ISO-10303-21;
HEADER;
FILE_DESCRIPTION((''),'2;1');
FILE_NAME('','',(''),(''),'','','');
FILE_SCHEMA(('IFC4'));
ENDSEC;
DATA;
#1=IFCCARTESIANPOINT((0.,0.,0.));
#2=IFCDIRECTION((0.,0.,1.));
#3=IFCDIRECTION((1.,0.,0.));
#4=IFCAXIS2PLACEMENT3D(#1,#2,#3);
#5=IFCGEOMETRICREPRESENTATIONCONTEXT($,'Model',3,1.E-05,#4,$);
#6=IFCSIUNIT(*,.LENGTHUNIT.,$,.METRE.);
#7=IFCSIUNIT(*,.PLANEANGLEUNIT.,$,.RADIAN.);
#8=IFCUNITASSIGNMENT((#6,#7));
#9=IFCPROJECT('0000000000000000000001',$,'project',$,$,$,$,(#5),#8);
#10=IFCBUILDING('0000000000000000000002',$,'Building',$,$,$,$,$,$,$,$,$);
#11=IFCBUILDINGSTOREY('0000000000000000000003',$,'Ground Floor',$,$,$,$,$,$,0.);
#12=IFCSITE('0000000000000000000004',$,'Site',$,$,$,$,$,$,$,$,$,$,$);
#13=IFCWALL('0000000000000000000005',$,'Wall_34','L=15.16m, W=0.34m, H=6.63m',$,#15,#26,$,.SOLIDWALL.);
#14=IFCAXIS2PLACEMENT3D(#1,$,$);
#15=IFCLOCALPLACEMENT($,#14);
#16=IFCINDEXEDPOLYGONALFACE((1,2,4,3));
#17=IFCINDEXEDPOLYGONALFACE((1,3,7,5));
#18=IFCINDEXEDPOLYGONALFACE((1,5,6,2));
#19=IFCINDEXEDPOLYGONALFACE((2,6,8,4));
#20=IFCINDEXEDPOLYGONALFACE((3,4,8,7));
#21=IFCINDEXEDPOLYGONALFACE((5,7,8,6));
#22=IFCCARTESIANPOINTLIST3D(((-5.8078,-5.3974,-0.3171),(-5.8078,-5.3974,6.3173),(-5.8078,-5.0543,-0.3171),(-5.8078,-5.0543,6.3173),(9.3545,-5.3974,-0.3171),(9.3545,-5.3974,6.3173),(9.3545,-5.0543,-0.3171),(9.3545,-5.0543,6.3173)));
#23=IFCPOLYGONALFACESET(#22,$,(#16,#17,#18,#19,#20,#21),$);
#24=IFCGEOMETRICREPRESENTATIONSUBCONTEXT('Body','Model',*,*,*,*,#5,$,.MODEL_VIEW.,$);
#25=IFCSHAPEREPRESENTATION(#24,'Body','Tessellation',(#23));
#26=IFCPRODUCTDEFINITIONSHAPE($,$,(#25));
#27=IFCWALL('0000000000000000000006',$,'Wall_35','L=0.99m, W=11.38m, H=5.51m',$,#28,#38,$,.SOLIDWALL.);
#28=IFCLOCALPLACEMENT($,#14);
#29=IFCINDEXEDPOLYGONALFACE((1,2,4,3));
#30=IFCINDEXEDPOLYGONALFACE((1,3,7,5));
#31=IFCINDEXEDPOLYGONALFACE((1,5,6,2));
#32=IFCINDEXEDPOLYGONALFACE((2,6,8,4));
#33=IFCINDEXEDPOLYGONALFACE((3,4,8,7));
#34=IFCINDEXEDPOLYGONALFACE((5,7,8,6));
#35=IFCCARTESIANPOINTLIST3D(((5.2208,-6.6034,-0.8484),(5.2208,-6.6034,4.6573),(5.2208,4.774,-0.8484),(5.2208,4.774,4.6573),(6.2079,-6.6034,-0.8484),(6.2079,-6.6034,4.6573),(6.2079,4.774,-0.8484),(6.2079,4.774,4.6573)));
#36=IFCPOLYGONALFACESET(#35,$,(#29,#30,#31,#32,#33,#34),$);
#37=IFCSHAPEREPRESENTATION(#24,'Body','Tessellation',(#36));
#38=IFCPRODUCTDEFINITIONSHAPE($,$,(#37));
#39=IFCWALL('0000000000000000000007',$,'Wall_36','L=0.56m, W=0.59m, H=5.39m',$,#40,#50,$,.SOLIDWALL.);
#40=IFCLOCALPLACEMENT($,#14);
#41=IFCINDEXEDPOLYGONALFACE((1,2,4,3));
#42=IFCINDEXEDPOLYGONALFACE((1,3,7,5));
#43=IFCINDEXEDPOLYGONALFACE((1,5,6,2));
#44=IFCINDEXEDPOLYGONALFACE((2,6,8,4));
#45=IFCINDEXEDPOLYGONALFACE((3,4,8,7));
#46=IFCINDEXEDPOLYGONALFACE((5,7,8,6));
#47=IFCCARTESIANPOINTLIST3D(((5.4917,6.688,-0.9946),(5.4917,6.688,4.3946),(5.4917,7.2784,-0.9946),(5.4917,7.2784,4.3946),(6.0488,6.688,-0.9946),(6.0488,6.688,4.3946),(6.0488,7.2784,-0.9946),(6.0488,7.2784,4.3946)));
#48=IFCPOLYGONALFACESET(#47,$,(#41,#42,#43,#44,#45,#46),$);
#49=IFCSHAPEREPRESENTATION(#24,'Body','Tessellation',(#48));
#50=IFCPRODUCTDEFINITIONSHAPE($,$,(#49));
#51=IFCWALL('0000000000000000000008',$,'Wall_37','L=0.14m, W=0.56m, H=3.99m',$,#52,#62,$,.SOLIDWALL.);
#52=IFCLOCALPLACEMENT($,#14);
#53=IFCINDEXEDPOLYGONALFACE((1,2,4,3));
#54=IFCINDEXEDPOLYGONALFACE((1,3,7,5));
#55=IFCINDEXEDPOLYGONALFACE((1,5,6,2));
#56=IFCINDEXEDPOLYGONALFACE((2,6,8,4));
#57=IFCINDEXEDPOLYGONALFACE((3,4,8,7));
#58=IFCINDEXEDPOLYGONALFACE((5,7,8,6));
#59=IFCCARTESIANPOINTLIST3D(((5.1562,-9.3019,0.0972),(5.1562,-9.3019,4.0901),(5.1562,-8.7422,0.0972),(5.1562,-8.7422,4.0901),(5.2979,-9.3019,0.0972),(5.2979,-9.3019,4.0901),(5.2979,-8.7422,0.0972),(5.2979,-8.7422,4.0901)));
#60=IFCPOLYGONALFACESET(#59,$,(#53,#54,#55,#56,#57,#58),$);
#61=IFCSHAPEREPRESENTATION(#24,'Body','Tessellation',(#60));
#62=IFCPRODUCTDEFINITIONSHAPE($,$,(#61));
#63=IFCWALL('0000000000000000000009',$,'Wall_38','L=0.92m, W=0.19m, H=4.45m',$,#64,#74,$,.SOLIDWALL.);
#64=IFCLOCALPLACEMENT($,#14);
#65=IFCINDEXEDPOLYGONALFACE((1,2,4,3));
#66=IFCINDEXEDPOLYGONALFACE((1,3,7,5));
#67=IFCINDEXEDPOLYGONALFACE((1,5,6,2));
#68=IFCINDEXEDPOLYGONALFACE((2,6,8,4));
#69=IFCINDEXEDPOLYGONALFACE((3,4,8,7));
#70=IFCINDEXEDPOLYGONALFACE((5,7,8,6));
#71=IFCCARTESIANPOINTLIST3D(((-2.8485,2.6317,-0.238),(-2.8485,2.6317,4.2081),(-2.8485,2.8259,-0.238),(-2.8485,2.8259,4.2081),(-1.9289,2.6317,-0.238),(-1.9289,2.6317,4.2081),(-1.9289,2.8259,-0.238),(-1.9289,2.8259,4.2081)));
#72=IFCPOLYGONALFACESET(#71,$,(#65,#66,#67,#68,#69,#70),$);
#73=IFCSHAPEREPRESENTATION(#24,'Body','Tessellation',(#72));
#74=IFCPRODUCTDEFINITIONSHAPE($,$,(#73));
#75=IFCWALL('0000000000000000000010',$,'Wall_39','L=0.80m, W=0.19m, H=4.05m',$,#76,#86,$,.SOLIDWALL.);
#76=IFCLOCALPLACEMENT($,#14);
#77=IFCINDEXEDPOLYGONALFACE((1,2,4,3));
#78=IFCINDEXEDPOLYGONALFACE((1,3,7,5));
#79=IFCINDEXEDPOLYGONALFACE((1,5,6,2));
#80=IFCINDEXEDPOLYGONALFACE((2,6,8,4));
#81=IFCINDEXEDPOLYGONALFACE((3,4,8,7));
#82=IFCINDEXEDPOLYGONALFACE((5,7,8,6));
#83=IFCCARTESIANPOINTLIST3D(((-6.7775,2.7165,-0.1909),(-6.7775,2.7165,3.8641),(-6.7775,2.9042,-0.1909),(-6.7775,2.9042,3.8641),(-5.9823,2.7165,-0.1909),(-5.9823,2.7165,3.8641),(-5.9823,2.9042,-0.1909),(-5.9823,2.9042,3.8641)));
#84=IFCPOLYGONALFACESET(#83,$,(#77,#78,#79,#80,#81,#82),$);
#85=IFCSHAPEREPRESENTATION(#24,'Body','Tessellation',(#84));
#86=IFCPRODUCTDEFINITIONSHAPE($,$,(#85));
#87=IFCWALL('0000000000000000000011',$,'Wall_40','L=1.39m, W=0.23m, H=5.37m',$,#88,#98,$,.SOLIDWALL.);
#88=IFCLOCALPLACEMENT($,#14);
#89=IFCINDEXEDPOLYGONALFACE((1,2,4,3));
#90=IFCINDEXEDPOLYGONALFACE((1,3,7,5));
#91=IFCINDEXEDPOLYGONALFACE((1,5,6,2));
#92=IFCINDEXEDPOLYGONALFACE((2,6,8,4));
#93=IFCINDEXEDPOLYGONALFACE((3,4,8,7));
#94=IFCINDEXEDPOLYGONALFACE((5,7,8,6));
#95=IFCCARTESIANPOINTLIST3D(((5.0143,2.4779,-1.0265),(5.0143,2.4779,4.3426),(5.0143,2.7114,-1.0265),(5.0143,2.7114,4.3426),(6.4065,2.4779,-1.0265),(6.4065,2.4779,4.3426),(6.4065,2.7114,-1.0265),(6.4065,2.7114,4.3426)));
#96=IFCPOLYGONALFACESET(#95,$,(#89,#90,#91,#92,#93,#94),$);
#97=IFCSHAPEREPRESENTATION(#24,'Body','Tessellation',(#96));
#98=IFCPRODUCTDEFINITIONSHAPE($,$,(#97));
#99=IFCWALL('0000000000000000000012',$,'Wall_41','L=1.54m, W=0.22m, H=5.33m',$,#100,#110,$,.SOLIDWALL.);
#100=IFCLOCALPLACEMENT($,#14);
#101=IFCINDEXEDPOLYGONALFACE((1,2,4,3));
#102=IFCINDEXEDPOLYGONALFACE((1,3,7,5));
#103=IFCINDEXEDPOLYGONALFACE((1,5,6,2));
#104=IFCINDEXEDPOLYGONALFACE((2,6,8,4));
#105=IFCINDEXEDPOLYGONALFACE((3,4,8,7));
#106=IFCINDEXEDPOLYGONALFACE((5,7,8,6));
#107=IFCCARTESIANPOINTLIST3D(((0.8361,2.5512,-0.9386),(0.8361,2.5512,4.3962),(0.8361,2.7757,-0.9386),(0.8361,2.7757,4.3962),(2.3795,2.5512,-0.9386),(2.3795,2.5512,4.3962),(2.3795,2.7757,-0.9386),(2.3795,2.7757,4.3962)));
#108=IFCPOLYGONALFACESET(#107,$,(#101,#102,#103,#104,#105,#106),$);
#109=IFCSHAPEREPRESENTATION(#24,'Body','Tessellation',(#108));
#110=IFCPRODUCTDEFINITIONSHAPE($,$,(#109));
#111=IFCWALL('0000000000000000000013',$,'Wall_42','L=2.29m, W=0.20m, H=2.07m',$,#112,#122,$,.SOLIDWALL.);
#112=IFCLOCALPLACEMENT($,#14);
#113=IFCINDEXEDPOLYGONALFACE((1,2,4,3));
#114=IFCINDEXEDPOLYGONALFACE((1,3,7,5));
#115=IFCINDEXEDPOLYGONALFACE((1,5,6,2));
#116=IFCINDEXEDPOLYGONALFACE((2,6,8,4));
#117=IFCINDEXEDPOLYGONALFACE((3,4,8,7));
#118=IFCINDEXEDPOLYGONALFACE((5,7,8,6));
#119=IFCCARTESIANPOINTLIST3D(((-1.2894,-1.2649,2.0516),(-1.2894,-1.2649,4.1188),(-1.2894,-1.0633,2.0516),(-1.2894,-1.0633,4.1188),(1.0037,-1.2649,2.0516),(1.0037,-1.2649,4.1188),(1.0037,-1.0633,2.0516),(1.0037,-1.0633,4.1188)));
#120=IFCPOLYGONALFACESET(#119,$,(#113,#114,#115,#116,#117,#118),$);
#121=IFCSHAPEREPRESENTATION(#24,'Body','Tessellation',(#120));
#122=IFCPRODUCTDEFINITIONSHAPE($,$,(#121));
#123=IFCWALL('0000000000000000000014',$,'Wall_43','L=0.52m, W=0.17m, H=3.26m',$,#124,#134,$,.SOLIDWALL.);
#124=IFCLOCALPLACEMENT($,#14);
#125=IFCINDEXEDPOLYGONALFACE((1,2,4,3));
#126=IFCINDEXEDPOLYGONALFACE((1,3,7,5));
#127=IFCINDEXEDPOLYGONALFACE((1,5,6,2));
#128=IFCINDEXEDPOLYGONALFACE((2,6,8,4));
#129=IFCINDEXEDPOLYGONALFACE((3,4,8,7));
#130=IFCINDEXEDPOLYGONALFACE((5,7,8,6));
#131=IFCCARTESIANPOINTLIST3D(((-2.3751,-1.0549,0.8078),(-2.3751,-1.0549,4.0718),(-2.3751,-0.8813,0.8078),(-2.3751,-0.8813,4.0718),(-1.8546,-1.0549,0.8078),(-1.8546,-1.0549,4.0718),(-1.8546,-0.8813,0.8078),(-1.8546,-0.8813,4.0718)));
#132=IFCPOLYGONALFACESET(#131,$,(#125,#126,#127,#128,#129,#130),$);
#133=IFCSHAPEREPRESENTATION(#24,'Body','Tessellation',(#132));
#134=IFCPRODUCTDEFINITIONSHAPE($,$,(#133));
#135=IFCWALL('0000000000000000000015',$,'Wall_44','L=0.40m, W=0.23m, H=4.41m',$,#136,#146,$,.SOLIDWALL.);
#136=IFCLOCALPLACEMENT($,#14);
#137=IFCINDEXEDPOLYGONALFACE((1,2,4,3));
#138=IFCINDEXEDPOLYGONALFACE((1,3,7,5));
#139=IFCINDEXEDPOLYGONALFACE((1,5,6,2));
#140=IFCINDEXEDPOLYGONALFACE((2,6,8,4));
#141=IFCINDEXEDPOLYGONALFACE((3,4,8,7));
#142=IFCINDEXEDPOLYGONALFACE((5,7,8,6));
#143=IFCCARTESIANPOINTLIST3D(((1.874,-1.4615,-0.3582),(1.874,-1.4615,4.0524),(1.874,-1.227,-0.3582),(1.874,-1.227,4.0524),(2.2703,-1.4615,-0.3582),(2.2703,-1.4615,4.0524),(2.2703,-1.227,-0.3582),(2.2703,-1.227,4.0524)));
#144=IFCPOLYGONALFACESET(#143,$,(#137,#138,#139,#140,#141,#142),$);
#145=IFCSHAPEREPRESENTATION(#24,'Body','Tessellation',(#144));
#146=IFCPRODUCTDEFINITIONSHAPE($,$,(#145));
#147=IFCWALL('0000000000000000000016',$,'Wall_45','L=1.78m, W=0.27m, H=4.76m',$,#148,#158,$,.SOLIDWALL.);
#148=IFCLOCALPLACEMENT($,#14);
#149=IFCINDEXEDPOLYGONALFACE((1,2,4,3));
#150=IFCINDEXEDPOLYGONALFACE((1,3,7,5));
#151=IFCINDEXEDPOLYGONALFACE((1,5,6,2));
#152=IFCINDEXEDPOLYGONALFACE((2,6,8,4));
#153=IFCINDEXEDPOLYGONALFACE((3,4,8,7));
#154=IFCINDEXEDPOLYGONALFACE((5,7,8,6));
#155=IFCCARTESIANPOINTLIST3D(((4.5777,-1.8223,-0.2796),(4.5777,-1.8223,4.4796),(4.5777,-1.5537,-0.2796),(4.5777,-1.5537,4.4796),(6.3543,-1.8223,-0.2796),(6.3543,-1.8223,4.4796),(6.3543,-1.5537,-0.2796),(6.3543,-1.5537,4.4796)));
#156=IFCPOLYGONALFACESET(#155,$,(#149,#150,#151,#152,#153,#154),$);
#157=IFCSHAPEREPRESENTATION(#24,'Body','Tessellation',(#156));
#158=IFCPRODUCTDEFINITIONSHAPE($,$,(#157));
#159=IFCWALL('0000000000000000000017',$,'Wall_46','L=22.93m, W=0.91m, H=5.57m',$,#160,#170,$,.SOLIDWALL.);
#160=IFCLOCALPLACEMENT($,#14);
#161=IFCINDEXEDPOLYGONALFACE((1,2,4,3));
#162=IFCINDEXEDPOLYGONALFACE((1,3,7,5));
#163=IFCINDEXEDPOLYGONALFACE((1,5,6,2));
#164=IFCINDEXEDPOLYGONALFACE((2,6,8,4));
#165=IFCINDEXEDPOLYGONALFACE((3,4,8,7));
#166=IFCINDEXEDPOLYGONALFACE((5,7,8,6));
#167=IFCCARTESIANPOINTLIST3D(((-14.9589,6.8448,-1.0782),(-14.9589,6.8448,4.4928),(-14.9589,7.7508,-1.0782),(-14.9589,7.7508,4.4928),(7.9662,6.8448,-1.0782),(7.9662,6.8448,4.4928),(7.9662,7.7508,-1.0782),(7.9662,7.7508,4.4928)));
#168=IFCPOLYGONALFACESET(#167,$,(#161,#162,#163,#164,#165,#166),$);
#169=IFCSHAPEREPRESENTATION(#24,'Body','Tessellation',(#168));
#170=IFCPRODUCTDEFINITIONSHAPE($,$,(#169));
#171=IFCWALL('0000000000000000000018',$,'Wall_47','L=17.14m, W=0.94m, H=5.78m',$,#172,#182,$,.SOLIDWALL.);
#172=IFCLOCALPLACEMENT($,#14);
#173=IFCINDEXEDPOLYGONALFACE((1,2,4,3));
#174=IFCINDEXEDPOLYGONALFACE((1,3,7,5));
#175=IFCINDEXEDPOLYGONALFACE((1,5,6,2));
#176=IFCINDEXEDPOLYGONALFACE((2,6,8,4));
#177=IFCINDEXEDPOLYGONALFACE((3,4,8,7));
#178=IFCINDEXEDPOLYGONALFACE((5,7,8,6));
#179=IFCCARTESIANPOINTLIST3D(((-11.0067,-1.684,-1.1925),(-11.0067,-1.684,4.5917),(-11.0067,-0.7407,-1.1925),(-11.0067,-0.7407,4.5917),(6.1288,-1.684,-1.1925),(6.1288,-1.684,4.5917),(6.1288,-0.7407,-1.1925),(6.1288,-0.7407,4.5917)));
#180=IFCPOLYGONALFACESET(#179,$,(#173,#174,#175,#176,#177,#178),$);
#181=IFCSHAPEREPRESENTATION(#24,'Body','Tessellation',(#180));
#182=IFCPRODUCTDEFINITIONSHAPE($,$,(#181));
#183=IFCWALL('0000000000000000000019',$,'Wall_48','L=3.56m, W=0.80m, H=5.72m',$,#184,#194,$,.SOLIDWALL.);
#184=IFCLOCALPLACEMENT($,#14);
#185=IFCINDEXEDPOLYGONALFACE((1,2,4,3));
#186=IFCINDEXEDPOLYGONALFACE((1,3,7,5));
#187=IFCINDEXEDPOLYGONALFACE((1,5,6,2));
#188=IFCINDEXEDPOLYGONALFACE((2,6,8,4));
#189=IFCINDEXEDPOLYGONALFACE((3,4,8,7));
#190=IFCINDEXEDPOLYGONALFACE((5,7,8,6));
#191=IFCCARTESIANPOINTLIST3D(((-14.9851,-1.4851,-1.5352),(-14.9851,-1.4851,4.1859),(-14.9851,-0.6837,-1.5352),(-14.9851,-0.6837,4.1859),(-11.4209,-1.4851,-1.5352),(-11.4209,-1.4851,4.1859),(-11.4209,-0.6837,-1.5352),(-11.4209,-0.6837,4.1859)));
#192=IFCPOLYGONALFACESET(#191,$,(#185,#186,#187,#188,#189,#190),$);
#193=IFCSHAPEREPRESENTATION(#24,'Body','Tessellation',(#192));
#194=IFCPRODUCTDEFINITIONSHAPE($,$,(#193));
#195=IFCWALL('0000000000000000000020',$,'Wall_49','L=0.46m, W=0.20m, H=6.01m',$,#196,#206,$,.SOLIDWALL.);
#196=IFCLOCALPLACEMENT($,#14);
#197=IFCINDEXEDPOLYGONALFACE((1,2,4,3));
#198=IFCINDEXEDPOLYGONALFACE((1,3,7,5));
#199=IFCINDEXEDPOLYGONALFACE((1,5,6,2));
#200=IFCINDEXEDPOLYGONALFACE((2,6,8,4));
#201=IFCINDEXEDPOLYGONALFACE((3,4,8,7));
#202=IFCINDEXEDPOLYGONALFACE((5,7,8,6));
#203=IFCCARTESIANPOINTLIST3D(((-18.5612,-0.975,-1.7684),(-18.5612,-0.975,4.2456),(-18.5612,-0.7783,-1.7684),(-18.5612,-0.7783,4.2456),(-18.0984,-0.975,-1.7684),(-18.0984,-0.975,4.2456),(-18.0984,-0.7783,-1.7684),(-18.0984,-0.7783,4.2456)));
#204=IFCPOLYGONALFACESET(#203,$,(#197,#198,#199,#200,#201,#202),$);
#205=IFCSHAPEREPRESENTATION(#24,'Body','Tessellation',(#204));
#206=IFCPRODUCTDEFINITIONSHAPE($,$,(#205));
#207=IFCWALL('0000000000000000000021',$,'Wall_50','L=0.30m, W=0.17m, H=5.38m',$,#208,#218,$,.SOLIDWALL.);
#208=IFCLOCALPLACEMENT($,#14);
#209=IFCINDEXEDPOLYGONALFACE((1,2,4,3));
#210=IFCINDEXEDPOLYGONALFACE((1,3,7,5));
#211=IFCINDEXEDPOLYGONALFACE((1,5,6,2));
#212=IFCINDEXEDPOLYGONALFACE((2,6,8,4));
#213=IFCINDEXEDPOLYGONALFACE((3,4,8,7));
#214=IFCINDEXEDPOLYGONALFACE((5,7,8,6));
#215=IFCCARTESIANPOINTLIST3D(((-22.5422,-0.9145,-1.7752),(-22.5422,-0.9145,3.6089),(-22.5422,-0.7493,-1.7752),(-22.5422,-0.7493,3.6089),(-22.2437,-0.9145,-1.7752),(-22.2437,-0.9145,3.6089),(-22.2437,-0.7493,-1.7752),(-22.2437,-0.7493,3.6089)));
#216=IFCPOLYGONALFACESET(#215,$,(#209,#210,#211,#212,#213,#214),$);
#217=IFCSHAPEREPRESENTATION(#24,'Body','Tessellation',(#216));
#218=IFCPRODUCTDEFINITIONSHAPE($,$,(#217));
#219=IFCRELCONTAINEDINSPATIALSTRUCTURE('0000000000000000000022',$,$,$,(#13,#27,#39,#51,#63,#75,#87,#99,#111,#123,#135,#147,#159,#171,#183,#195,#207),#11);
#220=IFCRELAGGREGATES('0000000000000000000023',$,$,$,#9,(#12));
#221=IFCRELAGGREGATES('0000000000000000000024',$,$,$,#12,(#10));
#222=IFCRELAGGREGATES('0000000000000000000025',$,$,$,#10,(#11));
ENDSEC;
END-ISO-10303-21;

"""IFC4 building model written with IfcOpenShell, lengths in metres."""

from ifc_helpers import new_model, si_unit, frame, origin_with_axes, origin_2d, context, subcontext, project, spatial, rectangle, extrude, element, save


model = new_model("IFC4")

# Units and contexts
model_context = context("Model", 3, precision=1e-05, world=origin_with_axes())
body_context = subcontext(model_context, "Body", "Model", "MODEL_VIEW")
ifc_project = project(units=[si_unit("LENGTHUNIT", "METRE"), si_unit("PLANEANGLEUNIT", "RADIAN")], contexts=[model_context])

# Site, building, storey
site = spatial("IfcSite", under=ifc_project, Name="Site")
building = spatial("IfcBuilding", under=site, Name="Building")
storey = spatial("IfcBuildingStorey", under=building, Name="Ground Floor", Elevation=0.0)

# Walls
element("IfcWall", 1, inside=storey, Name="Wall_34", Description="L=15.16m, W=0.34m, H=6.63m", PredefinedType="SOLIDWALL", context=body_context, shape_type="SweptSolid", body=[
    extrude(rectangle(XDim=15.1623, YDim=0.3431, at=origin_2d()), frame((1.7733, -5.2258, -0.3171), z_axis=(0.0, 0.0, 1.0), x_axis=(1.0, 0.0, 0.0)), (0.0, 0.0, 1.0), 6.6344),
])
element("IfcWall", 2, inside=storey, Name="Wall_35", Description="L=0.99m, W=11.38m, H=5.51m", PredefinedType="SOLIDWALL", context=body_context, shape_type="SweptSolid", body=[
    extrude(rectangle(XDim=0.9872, YDim=11.3773, at=origin_2d()), frame((5.7144, -0.9147, -0.8484), z_axis=(0.0, 0.0, 1.0), x_axis=(1.0, 0.0, 0.0)), (0.0, 0.0, 1.0), 5.5057),
])
element("IfcWall", 3, inside=storey, Name="Wall_36", Description="L=0.56m, W=0.59m, H=5.39m", PredefinedType="SOLIDWALL", context=body_context, shape_type="SweptSolid", body=[
    extrude(rectangle(XDim=0.557, YDim=0.5904, at=origin_2d()), frame((5.7703, 6.9832, -0.9946), z_axis=(0.0, 0.0, 1.0), x_axis=(1.0, 0.0, 0.0)), (0.0, 0.0, 1.0), 5.3891),
])
element("IfcWall", 4, inside=storey, Name="Wall_37", Description="L=0.14m, W=0.56m, H=3.99m", PredefinedType="SOLIDWALL", context=body_context, shape_type="SweptSolid", body=[
    extrude(rectangle(XDim=0.1417, YDim=0.5597, at=origin_2d()), frame((5.227, -9.0221, 0.0972), z_axis=(0.0, 0.0, 1.0), x_axis=(1.0, 0.0, 0.0)), (0.0, 0.0, 1.0), 3.9929),
])
element("IfcWall", 5, inside=storey, Name="Wall_38", Description="L=0.92m, W=0.19m, H=4.45m", PredefinedType="SOLIDWALL", context=body_context, shape_type="SweptSolid", body=[
    extrude(rectangle(XDim=0.9196, YDim=0.1942, at=origin_2d()), frame((-2.3887, 2.7288, -0.238), z_axis=(0.0, 0.0, 1.0), x_axis=(1.0, 0.0, 0.0)), (0.0, 0.0, 1.0), 4.4461),
])
element("IfcWall", 6, inside=storey, Name="Wall_39", Description="L=0.80m, W=0.19m, H=4.05m", PredefinedType="SOLIDWALL", context=body_context, shape_type="SweptSolid", body=[
    extrude(rectangle(XDim=0.7952, YDim=0.1877, at=origin_2d()), frame((-6.3799, 2.8103, -0.1909), z_axis=(0.0, 0.0, 1.0), x_axis=(1.0, 0.0, 0.0)), (0.0, 0.0, 1.0), 4.055),
])
element("IfcWall", 7, inside=storey, Name="Wall_40", Description="L=1.39m, W=0.23m, H=5.37m", PredefinedType="SOLIDWALL", context=body_context, shape_type="SweptSolid", body=[
    extrude(rectangle(XDim=1.3922, YDim=0.2334, at=origin_2d()), frame((5.7104, 2.5946, -1.0265), z_axis=(0.0, 0.0, 1.0), x_axis=(1.0, 0.0, 0.0)), (0.0, 0.0, 1.0), 5.369),
])
element("IfcWall", 8, inside=storey, Name="Wall_41", Description="L=1.54m, W=0.22m, H=5.33m", PredefinedType="SOLIDWALL", context=body_context, shape_type="SweptSolid", body=[
    extrude(rectangle(XDim=1.5434, YDim=0.2246, at=origin_2d()), frame((1.6078, 2.6634, -0.9386), z_axis=(0.0, 0.0, 1.0), x_axis=(1.0, 0.0, 0.0)), (0.0, 0.0, 1.0), 5.3348),
])
element("IfcWall", 9, inside=storey, Name="Wall_42", Description="L=2.29m, W=0.20m, H=2.07m", PredefinedType="SOLIDWALL", context=body_context, shape_type="SweptSolid", body=[
    extrude(rectangle(XDim=2.293, YDim=0.2016, at=origin_2d()), frame((-0.1429, -1.1641, 2.0516), z_axis=(0.0, 0.0, 1.0), x_axis=(1.0, 0.0, 0.0)), (0.0, 0.0, 1.0), 2.0672),
])
element("IfcWall", 10, inside=storey, Name="Wall_43", Description="L=0.52m, W=0.17m, H=3.26m", PredefinedType="SOLIDWALL", context=body_context, shape_type="SweptSolid", body=[
    extrude(rectangle(XDim=0.5205, YDim=0.1736, at=origin_2d()), frame((-2.1148, -0.9681, 0.8078), z_axis=(0.0, 0.0, 1.0), x_axis=(1.0, 0.0, 0.0)), (0.0, 0.0, 1.0), 3.264),
])
element("IfcWall", 11, inside=storey, Name="Wall_44", Description="L=0.40m, W=0.23m, H=4.41m", PredefinedType="SOLIDWALL", context=body_context, shape_type="SweptSolid", body=[
    extrude(rectangle(XDim=0.3962, YDim=0.2344, at=origin_2d()), frame((2.0721, -1.3442, -0.3582), z_axis=(0.0, 0.0, 1.0), x_axis=(1.0, 0.0, 0.0)), (0.0, 0.0, 1.0), 4.4106),
])
element("IfcWall", 12, inside=storey, Name="Wall_45", Description="L=1.78m, W=0.27m, H=4.76m", PredefinedType="SOLIDWALL", context=body_context, shape_type="SweptSolid", body=[
    extrude(rectangle(XDim=1.7765, YDim=0.2686, at=origin_2d()), frame((5.466, -1.688, -0.2796), z_axis=(0.0, 0.0, 1.0), x_axis=(1.0, 0.0, 0.0)), (0.0, 0.0, 1.0), 4.7592),
])
element("IfcWall", 13, inside=storey, Name="Wall_46", Description="L=22.93m, W=0.91m, H=5.57m", PredefinedType="SOLIDWALL", context=body_context, shape_type="SweptSolid", body=[
    extrude(rectangle(XDim=22.9251, YDim=0.906, at=origin_2d()), frame((-3.4964, 7.2978, -1.0782), z_axis=(0.0, 0.0, 1.0), x_axis=(1.0, 0.0, 0.0)), (0.0, 0.0, 1.0), 5.571),
])
element("IfcWall", 14, inside=storey, Name="Wall_47", Description="L=17.14m, W=0.94m, H=5.78m", PredefinedType="SOLIDWALL", context=body_context, shape_type="SweptSolid", body=[
    extrude(rectangle(XDim=17.1355, YDim=0.9433, at=origin_2d()), frame((-2.4389, -1.2124, -1.1925), z_axis=(0.0, 0.0, 1.0), x_axis=(1.0, 0.0, 0.0)), (0.0, 0.0, 1.0), 5.7842),
])
element("IfcWall", 15, inside=storey, Name="Wall_48", Description="L=3.56m, W=0.80m, H=5.72m", PredefinedType="SOLIDWALL", context=body_context, shape_type="SweptSolid", body=[
    extrude(rectangle(XDim=3.5642, YDim=0.8014, at=origin_2d()), frame((-13.203, -1.0844, -1.5352), z_axis=(0.0, 0.0, 1.0), x_axis=(1.0, 0.0, 0.0)), (0.0, 0.0, 1.0), 5.7211),
])
element("IfcWall", 16, inside=storey, Name="Wall_49", Description="L=0.46m, W=0.20m, H=6.01m", PredefinedType="SOLIDWALL", context=body_context, shape_type="SweptSolid", body=[
    extrude(rectangle(XDim=0.4628, YDim=0.1967, at=origin_2d()), frame((-18.3298, -0.8766, -1.7684), z_axis=(0.0, 0.0, 1.0), x_axis=(1.0, 0.0, 0.0)), (0.0, 0.0, 1.0), 6.014),
])
element("IfcWall", 17, inside=storey, Name="Wall_50", Description="L=0.30m, W=0.17m, H=5.38m", PredefinedType="SOLIDWALL", context=body_context, shape_type="SweptSolid", body=[
    extrude(rectangle(XDim=0.2985, YDim=0.1652, at=origin_2d()), frame((-22.3929, -0.8319, -1.7752), z_axis=(0.0, 0.0, 1.0), x_axis=(1.0, 0.0, 0.0)), (0.0, 0.0, 1.0), 5.3841),
])

save(model, "model.ifc")
